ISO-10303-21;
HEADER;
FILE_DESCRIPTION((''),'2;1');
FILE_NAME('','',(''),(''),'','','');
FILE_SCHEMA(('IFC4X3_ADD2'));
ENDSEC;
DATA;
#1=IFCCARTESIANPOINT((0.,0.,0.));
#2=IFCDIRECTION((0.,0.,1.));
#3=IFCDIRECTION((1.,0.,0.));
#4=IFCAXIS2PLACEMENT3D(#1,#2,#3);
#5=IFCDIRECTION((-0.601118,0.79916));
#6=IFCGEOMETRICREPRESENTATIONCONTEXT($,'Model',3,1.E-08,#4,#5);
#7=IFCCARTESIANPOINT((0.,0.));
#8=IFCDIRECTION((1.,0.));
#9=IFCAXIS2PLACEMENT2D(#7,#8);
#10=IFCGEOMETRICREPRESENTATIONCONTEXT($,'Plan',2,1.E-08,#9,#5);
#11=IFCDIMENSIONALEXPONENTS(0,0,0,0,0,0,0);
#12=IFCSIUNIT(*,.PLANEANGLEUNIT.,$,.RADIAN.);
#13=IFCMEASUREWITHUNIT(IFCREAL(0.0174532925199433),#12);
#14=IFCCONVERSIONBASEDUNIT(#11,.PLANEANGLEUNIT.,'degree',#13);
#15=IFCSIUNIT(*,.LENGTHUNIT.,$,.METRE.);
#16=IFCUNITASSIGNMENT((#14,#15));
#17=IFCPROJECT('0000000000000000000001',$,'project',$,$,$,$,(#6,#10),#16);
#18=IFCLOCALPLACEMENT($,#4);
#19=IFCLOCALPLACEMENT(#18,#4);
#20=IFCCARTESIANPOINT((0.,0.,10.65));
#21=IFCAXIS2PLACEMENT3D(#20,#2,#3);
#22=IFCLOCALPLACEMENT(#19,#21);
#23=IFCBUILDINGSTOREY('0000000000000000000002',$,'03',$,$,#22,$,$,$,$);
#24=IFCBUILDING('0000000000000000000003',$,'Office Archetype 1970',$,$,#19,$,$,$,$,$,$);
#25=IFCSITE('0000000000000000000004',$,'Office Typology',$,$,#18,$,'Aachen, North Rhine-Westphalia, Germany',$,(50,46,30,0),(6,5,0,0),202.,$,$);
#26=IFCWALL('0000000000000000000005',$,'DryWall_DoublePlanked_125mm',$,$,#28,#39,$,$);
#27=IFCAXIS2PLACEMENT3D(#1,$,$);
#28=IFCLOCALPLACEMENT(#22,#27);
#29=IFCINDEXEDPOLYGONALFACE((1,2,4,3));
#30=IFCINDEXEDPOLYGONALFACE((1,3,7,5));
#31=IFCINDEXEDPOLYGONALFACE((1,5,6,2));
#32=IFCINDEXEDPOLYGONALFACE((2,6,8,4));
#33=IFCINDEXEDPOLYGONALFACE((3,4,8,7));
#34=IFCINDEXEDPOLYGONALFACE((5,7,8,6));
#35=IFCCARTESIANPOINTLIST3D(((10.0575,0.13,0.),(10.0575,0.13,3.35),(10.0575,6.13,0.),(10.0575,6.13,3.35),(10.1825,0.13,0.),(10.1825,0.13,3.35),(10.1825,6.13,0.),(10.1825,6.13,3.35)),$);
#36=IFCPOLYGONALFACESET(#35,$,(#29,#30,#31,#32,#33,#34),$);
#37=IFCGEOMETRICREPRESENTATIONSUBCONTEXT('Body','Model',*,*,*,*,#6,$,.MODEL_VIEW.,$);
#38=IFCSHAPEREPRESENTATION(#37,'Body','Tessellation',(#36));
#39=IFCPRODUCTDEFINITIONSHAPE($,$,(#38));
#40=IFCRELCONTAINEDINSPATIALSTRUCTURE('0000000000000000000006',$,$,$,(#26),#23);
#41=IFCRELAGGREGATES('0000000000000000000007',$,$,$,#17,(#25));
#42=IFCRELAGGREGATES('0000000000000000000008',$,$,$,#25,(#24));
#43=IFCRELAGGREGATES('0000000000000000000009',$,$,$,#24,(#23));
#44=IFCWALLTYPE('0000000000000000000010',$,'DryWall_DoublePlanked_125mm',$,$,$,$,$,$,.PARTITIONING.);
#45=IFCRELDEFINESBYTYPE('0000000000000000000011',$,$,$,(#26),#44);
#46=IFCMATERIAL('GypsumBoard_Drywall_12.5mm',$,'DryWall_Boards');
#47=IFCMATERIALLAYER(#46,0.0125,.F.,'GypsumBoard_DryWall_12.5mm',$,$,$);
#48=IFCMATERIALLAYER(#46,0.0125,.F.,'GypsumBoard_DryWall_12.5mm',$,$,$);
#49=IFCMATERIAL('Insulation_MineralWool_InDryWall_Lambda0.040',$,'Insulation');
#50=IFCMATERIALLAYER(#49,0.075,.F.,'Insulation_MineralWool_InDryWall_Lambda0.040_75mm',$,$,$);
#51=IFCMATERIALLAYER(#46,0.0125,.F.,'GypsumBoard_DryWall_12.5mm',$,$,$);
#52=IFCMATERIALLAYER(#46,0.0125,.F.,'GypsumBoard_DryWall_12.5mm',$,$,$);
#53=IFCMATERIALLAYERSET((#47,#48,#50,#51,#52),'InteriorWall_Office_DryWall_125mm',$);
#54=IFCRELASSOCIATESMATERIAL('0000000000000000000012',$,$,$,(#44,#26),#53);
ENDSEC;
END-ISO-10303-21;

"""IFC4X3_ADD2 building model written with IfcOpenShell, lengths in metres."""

from ifc_helpers import new_model, entity, si_unit, converted_unit, direction, frame, origin_with_axes, origin_2d_with_axis, place, context, subcontext, project, spatial, line, indexed_curve, outline, extrude, material, layer, layer_set, layer_usage, type_object, element, save


model = new_model("IFC4X3_ADD2")

# Units and contexts
model_context = context("Model", 3, precision=1e-08, world=origin_with_axes(), true_north=direction((-0.601118, 0.79916)))
plan_context = context("Plan", 2, precision=1e-08, world=origin_2d_with_axis(), true_north=direction((-0.601118, 0.79916)))
body_context = subcontext(model_context, "Body", "Model", "MODEL_VIEW")
ifc_project = project(units=[converted_unit("PLANEANGLEUNIT", "degree", entity("IfcReal", 0.0174532925199433), si_unit("PLANEANGLEUNIT", "RADIAN"), dimensions=[0, 0, 0, 0, 0, 0, 0]), si_unit("LENGTHUNIT", "METRE")], contexts=[model_context, plan_context])

# Site, building, storey
site_placement = place(None, origin_with_axes())
site = spatial("IfcSite", under=ifc_project, at=site_placement, Name="Office Typology", LongName="Aachen, North Rhine-Westphalia, Germany", RefLatitude=(50, 46, 30, 0), RefLongitude=(6, 5, 0, 0), RefElevation=202.0)
building_placement = place(site_placement, origin_with_axes())
building = spatial("IfcBuilding", under=site, at=building_placement, Name="Office Archetype 1970")
storey_placement = place(building_placement, frame((0.0, 0.0, 10.65), z_axis=(0.0, 0.0, 1.0), x_axis=(1.0, 0.0, 0.0)))
storey = spatial("IfcBuildingStorey", under=building, at=storey_placement, Name="03")

# Wall
ifc_material_1 = material(Name="GypsumBoard_Drywall_12.5mm", Category="DryWall_Boards")
ifc_layer_1 = layer(ifc_material_1, 0.0125, ventilated=False, Name="GypsumBoard_DryWall_12.5mm")
ifc_layer_2 = layer(ifc_material_1, 0.0125, ventilated=False, Name="GypsumBoard_DryWall_12.5mm")
ifc_material_2 = material(Name="Insulation_MineralWool_InDryWall_Lambda0.040", Category="Insulation")
ifc_layer_3 = layer(ifc_material_2, 0.075, ventilated=False, Name="Insulation_MineralWool_InDryWall_Lambda0.040_75mm")
ifc_layer_4 = layer(ifc_material_1, 0.0125, ventilated=False, Name="GypsumBoard_DryWall_12.5mm")
ifc_layer_5 = layer(ifc_material_1, 0.0125, ventilated=False, Name="GypsumBoard_DryWall_12.5mm")
ifc_layer_set_1 = layer_set([ifc_layer_1, ifc_layer_2, ifc_layer_3, ifc_layer_4, ifc_layer_5], Name="InteriorWall_Office_DryWall_125mm")
wall_type_1 = type_object("IfcWallType", Name="DryWall_DoublePlanked_125mm", PredefinedType="PARTITIONING", material=ifc_layer_set_1)
ifc_layer_usage_1 = layer_usage(ifc_layer_set_1, "AXIS2", "POSITIVE", 0.0)
wall_1_placement = place(storey_placement, frame((10.0575, 6.13, 0.0), z_axis=(0.0, 0.0, 1.0), x_axis=(0.0, -1.0, 0.0)))
element("IfcWall", 1, at=wall_1_placement, inside=storey, type_object=wall_type_1, material=ifc_layer_usage_1, Name="DryWall_DoublePlanked_125mm", context=body_context, shape_type="SweptSolid", body=[
    extrude(outline(indexed_curve([(0.0, 0.0), (0.0, 0.125), (6.0, 0.125), (6.0, 0.0)], segments=[line(1, 2, 3, 4, 1)])), origin_with_axes(), (0.0, 0.0, 1.0), 3.35),
])

save(model, "model.ifc")
